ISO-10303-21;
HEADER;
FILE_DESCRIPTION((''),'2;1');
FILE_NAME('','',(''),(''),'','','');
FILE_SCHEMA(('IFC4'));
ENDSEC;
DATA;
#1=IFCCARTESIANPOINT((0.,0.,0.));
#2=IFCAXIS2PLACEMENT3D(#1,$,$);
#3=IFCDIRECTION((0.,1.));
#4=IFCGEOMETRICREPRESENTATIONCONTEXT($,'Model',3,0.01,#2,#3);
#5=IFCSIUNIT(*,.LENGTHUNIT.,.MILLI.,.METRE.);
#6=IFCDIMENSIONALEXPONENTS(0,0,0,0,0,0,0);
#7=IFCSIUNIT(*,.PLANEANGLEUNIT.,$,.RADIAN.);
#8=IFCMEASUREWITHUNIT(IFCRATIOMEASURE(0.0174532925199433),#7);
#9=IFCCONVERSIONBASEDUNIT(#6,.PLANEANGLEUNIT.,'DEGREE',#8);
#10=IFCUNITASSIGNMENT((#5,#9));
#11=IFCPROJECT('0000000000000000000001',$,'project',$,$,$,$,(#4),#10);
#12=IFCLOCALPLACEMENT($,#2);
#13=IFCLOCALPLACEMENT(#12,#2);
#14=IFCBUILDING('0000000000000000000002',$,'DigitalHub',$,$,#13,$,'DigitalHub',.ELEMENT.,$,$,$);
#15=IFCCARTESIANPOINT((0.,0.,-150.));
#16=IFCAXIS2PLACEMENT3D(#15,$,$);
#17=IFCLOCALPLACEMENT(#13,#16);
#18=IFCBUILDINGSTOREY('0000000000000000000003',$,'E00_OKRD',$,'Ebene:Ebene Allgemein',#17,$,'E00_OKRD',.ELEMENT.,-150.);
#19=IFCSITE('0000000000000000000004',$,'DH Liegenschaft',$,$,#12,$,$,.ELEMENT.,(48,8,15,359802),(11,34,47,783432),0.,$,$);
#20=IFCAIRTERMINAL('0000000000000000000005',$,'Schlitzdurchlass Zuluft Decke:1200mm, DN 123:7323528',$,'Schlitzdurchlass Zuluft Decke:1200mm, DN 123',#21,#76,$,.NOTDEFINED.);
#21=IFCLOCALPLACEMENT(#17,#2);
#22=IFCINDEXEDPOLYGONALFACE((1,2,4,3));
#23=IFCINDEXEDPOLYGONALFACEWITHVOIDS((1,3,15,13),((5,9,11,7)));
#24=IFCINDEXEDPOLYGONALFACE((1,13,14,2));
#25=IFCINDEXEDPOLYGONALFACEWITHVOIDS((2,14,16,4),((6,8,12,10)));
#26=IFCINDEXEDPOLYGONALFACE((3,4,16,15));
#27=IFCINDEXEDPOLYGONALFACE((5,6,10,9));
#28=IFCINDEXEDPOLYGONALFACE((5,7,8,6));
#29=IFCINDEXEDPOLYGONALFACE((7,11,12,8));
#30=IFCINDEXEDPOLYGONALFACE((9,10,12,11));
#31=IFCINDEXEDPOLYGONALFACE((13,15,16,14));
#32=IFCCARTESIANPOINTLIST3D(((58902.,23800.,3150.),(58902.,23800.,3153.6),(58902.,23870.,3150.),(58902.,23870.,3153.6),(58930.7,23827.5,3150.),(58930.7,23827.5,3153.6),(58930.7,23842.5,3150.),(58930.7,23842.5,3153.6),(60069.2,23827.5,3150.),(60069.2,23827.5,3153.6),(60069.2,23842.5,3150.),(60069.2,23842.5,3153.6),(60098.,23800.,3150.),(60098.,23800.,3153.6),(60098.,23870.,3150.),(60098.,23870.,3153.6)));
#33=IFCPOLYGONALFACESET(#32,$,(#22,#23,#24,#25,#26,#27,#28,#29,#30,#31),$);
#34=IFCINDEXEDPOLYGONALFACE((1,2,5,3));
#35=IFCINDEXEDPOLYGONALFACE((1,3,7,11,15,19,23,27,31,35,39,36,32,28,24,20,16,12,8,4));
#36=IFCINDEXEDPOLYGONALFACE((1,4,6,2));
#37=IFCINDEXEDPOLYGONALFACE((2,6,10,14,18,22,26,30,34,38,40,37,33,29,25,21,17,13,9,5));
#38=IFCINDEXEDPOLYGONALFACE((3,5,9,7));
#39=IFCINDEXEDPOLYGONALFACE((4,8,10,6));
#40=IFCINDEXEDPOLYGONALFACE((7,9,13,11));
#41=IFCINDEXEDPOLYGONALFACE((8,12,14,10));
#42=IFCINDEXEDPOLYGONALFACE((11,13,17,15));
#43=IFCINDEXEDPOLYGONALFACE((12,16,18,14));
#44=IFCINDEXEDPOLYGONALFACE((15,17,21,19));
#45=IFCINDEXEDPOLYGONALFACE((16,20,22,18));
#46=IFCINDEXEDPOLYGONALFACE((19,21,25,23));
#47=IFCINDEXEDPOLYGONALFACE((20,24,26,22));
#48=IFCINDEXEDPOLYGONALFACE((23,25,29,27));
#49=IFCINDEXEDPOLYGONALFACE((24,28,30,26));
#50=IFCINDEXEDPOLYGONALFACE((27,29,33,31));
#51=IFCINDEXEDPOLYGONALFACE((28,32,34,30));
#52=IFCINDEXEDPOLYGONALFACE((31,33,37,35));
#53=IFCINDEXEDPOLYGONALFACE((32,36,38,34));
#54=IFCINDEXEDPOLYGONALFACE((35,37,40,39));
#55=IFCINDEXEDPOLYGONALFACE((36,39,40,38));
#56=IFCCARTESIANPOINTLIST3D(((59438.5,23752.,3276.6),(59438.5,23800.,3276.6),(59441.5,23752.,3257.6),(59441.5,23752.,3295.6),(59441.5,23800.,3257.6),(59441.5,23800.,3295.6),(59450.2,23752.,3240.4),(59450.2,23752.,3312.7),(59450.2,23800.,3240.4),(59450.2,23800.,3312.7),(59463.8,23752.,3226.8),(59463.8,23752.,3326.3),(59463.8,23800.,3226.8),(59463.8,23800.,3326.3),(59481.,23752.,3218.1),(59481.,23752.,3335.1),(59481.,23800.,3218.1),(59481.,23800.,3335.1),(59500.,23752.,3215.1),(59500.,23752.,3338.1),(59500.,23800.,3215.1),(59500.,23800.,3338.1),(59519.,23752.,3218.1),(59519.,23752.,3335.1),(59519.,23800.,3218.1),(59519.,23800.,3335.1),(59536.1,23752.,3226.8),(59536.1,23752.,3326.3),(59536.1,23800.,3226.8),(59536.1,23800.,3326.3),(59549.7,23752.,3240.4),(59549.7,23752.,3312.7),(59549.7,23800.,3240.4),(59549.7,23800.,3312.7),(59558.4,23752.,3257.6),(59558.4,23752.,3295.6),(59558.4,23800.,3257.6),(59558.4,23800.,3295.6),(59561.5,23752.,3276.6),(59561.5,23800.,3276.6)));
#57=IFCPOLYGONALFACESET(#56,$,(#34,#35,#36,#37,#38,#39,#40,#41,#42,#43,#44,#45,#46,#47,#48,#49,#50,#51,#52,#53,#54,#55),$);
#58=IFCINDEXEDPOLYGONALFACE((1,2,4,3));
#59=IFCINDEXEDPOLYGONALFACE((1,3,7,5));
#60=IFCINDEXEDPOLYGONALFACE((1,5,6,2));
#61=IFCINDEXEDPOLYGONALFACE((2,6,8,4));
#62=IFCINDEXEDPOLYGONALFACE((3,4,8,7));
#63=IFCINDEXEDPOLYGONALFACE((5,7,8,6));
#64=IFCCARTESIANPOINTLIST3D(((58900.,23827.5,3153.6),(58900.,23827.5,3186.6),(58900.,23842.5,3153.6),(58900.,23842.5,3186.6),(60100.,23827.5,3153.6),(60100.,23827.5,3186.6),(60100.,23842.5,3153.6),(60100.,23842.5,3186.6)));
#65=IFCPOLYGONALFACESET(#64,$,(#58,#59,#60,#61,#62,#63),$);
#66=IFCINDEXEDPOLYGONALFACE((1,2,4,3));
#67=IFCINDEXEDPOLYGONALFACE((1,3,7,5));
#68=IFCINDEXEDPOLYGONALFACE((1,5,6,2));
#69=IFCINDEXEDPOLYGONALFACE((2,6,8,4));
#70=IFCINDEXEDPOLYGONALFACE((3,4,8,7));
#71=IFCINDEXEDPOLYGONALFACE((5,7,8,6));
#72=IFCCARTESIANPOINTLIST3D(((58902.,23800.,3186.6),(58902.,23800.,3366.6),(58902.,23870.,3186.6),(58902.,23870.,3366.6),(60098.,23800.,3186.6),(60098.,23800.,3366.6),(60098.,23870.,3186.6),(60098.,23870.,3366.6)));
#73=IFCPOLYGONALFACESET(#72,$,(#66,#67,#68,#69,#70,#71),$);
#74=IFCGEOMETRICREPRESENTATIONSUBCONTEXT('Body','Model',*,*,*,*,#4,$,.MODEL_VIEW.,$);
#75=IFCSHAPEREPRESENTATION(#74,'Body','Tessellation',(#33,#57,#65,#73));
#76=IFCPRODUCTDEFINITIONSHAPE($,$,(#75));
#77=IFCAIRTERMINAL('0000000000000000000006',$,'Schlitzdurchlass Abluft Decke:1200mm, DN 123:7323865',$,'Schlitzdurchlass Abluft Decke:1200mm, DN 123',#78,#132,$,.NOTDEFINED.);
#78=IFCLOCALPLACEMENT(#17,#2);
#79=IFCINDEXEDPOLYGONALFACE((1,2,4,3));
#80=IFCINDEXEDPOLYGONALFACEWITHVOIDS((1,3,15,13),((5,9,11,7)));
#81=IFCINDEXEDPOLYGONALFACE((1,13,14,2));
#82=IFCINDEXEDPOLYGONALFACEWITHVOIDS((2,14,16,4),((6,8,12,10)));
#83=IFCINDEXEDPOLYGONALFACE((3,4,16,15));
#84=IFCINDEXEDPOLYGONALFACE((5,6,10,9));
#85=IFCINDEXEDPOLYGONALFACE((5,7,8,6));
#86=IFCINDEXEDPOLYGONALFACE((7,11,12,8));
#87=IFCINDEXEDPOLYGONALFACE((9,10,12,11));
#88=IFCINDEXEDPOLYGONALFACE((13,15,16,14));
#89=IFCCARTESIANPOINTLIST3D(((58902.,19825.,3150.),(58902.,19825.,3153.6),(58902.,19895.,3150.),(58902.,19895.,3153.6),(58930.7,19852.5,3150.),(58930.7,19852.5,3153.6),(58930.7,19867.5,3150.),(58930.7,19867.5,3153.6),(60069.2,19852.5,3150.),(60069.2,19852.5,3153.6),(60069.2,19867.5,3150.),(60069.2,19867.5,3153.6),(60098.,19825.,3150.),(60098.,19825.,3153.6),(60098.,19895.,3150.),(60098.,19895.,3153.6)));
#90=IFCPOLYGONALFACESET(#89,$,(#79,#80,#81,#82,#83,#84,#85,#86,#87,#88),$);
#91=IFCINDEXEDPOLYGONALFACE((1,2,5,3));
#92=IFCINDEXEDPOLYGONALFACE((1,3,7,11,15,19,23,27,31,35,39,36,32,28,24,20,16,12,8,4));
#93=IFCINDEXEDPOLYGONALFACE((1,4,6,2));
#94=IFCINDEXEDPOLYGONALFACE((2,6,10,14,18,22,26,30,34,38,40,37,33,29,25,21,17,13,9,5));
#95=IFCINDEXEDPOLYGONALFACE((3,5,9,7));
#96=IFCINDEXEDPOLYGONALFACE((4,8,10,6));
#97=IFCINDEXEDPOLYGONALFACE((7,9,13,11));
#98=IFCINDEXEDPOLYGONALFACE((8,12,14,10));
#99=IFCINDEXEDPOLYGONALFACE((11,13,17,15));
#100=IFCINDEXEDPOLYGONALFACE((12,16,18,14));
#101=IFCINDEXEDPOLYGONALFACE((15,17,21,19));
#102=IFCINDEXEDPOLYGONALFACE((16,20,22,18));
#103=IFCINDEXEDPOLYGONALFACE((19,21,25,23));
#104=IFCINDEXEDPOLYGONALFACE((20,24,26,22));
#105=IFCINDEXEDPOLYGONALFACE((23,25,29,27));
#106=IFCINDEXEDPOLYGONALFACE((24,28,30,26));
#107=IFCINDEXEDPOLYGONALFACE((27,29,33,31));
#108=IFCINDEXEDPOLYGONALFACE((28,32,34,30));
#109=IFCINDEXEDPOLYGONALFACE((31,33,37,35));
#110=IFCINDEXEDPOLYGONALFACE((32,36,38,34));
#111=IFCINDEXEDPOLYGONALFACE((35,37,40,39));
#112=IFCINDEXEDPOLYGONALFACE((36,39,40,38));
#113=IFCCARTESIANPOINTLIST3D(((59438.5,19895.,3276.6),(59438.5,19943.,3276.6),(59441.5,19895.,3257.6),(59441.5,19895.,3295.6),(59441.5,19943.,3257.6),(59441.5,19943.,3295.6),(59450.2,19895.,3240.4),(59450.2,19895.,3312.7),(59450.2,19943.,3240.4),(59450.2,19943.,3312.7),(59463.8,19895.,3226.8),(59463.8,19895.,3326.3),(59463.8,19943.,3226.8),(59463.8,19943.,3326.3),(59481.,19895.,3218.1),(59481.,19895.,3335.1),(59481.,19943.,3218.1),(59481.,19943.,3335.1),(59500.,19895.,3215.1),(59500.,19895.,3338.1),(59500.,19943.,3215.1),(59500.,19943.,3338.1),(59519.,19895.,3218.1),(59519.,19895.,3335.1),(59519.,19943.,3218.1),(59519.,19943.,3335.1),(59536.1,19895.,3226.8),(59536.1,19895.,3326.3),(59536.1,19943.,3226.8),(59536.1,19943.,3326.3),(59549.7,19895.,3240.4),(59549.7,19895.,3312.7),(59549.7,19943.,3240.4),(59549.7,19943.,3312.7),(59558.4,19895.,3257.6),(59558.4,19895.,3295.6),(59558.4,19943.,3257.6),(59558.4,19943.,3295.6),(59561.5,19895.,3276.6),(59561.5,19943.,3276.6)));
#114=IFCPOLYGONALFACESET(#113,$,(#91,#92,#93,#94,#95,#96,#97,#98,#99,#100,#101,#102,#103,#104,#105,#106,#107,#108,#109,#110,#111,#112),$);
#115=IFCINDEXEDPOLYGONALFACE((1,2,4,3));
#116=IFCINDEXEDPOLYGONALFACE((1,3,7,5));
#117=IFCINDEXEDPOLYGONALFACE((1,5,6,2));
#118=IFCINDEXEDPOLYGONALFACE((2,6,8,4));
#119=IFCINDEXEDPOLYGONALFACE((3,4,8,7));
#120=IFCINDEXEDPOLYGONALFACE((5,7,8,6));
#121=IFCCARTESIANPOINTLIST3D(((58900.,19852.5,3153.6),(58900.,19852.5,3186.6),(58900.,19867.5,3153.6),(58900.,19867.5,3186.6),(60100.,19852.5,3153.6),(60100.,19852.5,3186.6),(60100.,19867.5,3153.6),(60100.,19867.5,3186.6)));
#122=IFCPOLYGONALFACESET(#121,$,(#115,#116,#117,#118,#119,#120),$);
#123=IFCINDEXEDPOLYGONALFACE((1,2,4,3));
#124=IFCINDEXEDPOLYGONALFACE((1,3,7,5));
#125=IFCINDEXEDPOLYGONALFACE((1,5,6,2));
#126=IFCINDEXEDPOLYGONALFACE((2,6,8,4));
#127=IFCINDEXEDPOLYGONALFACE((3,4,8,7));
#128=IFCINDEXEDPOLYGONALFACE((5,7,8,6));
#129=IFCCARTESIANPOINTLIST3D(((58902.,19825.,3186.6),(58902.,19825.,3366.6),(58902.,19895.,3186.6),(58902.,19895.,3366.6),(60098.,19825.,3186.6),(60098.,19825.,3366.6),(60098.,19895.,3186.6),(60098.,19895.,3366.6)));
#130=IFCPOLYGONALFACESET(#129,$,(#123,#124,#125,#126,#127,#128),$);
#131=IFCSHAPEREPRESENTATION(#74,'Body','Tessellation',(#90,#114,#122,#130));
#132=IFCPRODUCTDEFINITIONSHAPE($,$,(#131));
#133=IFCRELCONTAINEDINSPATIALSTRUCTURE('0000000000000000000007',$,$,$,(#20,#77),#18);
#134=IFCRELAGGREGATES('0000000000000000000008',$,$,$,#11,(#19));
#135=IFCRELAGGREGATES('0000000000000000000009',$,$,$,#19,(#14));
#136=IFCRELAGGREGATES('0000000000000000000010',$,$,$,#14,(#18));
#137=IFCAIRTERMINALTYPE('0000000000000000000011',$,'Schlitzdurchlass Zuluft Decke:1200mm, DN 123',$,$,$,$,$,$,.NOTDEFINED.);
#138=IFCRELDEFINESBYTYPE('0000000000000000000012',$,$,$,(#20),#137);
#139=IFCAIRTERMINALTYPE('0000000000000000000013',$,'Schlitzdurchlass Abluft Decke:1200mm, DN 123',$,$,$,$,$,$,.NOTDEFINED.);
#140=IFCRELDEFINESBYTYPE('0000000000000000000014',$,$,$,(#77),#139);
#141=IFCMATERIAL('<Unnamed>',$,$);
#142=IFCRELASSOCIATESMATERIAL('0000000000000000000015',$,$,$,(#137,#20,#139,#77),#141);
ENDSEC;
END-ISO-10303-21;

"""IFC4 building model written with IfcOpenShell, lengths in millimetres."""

from ifc_helpers import new_model, entity, si_unit, converted_unit, direction, frame, origin, place, context, subcontext, project, spatial, indexed_curve, outline, extrude, source, transform, mapped, material, type_object, type_shapes, element, save


model = new_model("IFC4")

# Units and contexts
model_context = context("Model", 3, precision=0.01, world=origin(), true_north=direction((0.0, 1.0)))
body_context = subcontext(model_context, "Body", "Model", "MODEL_VIEW")
ifc_project = project(units=[si_unit("LENGTHUNIT", "METRE", prefix="MILLI"), converted_unit("PLANEANGLEUNIT", "DEGREE", entity("IfcRatioMeasure", 0.0174532925199433), si_unit("PLANEANGLEUNIT", "RADIAN"), dimensions=[0, 0, 0, 0, 0, 0, 0])], contexts=[model_context])

# Site, building, storey
site_placement = place(None, origin())
site = spatial("IfcSite", under=ifc_project, at=site_placement, Name="DH Liegenschaft", CompositionType="ELEMENT", RefLatitude=(48, 8, 15, 359802), RefLongitude=(11, 34, 47, 783432), RefElevation=0.0)
building_placement = place(site_placement, origin())
building = spatial("IfcBuilding", under=site, at=building_placement, Name="DigitalHub", LongName="DigitalHub", CompositionType="ELEMENT")
storey_placement = place(building_placement, frame((0.0, 0.0, -150.0)))
storey = spatial("IfcBuildingStorey", under=building, at=storey_placement, Name="E00_OKRD", ObjectType="Ebene:Ebene Allgemein", LongName="E00_OKRD", CompositionType="ELEMENT", Elevation=-150.0)

# Air terminals
ifc_material_1 = material(Name="<Unnamed>")
air_terminal_type_1 = type_object("IfcAirTerminalType", Name="Schlitzdurchlass Zuluft Decke:1200mm, DN 123", PredefinedType="NOTDEFINED", material=ifc_material_1)
shared_shape_1 = source(origin(), body_context, "Body", "SweptSolid", [
    extrude(outline(indexed_curve([(-598.0, -35.0), (598.0, -35.0), (598.0, 35.0), (-598.0, 35.0), (-598.0, -35.0)], self_intersect=False), holes=[indexed_curve([(-569.2, -7.5), (-569.2, 7.5), (569.2, 7.5), (569.2, -7.5), (-569.2, -7.5)], self_intersect=False)]), frame((600.0, 35.0, 0.0), z_axis=(0.0, 0.0, 1.0), x_axis=(-1.0, 0.0, 0.0)), (0.0, 0.0, 1.0), 3.6),
    extrude(outline(indexed_curve([(61.5, 0.0), (58.5, 19.0), (49.8, 36.1), (36.1, 49.8), (19.0, 58.5), (0.0, 61.5), (-19.0, 58.5), (-36.1, 49.8), (-49.8, 36.1), (-58.5, 19.0), (-61.5, 0.0), (-58.5, -19.0), (-49.8, -36.1), (-36.1, -49.8), (-19.0, -58.5), (0.0, -61.5), (19.0, -58.5), (36.1, -49.8), (49.8, -36.1), (58.5, -19.0), (61.5, 0.0)], self_intersect=False)), frame((600.0, 70.0, 126.6), z_axis=(0.0, 1.0, 0.0), x_axis=(-1.0, 0.0, 0.0)), (0.0, 0.0, 1.0), 48.0),
    extrude(outline(indexed_curve([(-600.0, -7.5), (600.0, -7.5), (600.0, 7.5), (-600.0, 7.5), (-600.0, -7.5)], self_intersect=False)), frame((600.0, 35.0, 3.6), z_axis=(0.0, 0.0, 1.0), x_axis=(-1.0, 0.0, 0.0)), (0.0, 0.0, 1.0), 33.0),
    extrude(outline(indexed_curve([(-598.0, -35.0), (598.0, -35.0), (598.0, 35.0), (-598.0, 35.0), (-598.0, -35.0)], self_intersect=False)), frame((600.0, 35.0, 36.6), z_axis=(0.0, 0.0, 1.0), x_axis=(-1.0, 0.0, 0.0)), (0.0, 0.0, 1.0), 180.0),
])
type_shapes(air_terminal_type_1, [shared_shape_1])
air_terminal_1_placement = place(storey_placement, frame((60100.0, 23870.0, 3150.0), z_axis=(0.0, 0.0, 1.0), x_axis=(-1.0, 0.0, 0.0)))
element("IfcAirTerminal", 1, at=air_terminal_1_placement, inside=storey, type_object=air_terminal_type_1, material=ifc_material_1, Name="Schlitzdurchlass Zuluft Decke:1200mm, DN 123:7323528", ObjectType="Schlitzdurchlass Zuluft Decke:1200mm, DN 123", PredefinedType="NOTDEFINED", context=body_context, shape_type="MappedRepresentation", body=[
    mapped(shared_shape_1, transform((0.0, 0.0, 0.0), scale=1.0)),
])
air_terminal_type_2 = type_object("IfcAirTerminalType", Name="Schlitzdurchlass Abluft Decke:1200mm, DN 123", PredefinedType="NOTDEFINED", material=ifc_material_1)
shared_shape_2 = source(origin(), body_context, "Body", "SweptSolid", [
    extrude(outline(indexed_curve([(-598.0, -35.0), (598.0, -35.0), (598.0, 35.0), (-598.0, 35.0), (-598.0, -35.0)], self_intersect=False), holes=[indexed_curve([(-569.2, -7.5), (-569.2, 7.5), (569.2, 7.5), (569.2, -7.5), (-569.2, -7.5)], self_intersect=False)]), frame((0.0, 0.0, 0.0), z_axis=(0.0, 0.0, 1.0), x_axis=(-1.0, 0.0, 0.0)), (0.0, 0.0, 1.0), 3.6),
    extrude(outline(indexed_curve([(61.5, 0.0), (58.5, 19.0), (49.8, 36.1), (36.1, 49.8), (19.0, 58.5), (0.0, 61.5), (-19.0, 58.5), (-36.1, 49.8), (-49.8, 36.1), (-58.5, 19.0), (-61.5, 0.0), (-58.5, -19.0), (-49.8, -36.1), (-36.1, -49.8), (-19.0, -58.5), (0.0, -61.5), (19.0, -58.5), (36.1, -49.8), (49.8, -36.1), (58.5, -19.0), (61.5, 0.0)], self_intersect=False)), frame((0.0, 35.0, 126.6), z_axis=(0.0, 1.0, 0.0), x_axis=(-1.0, 0.0, 0.0)), (0.0, 0.0, 1.0), 48.0),
    extrude(outline(indexed_curve([(-600.0, -7.5), (600.0, -7.5), (600.0, 7.5), (-600.0, 7.5), (-600.0, -7.5)], self_intersect=False)), frame((0.0, 0.0, 3.6), z_axis=(0.0, 0.0, 1.0), x_axis=(-1.0, 0.0, 0.0)), (0.0, 0.0, 1.0), 33.0),
    extrude(outline(indexed_curve([(-598.0, -35.0), (598.0, -35.0), (598.0, 35.0), (-598.0, 35.0), (-598.0, -35.0)], self_intersect=False)), frame((0.0, 0.0, 36.6), z_axis=(0.0, 0.0, 1.0), x_axis=(-1.0, 0.0, 0.0)), (0.0, 0.0, 1.0), 180.0),
])
type_shapes(air_terminal_type_2, [shared_shape_2])
air_terminal_2_placement = place(storey_placement, frame((59500.0, 19860.0, 3150.0)))
element("IfcAirTerminal", 2, at=air_terminal_2_placement, inside=storey, type_object=air_terminal_type_2, material=ifc_material_1, Name="Schlitzdurchlass Abluft Decke:1200mm, DN 123:7323865", ObjectType="Schlitzdurchlass Abluft Decke:1200mm, DN 123", PredefinedType="NOTDEFINED", context=body_context, shape_type="MappedRepresentation", body=[
    mapped(shared_shape_2, transform((0.0, 0.0, 0.0), scale=1.0)),
])

save(model, "model.ifc")
